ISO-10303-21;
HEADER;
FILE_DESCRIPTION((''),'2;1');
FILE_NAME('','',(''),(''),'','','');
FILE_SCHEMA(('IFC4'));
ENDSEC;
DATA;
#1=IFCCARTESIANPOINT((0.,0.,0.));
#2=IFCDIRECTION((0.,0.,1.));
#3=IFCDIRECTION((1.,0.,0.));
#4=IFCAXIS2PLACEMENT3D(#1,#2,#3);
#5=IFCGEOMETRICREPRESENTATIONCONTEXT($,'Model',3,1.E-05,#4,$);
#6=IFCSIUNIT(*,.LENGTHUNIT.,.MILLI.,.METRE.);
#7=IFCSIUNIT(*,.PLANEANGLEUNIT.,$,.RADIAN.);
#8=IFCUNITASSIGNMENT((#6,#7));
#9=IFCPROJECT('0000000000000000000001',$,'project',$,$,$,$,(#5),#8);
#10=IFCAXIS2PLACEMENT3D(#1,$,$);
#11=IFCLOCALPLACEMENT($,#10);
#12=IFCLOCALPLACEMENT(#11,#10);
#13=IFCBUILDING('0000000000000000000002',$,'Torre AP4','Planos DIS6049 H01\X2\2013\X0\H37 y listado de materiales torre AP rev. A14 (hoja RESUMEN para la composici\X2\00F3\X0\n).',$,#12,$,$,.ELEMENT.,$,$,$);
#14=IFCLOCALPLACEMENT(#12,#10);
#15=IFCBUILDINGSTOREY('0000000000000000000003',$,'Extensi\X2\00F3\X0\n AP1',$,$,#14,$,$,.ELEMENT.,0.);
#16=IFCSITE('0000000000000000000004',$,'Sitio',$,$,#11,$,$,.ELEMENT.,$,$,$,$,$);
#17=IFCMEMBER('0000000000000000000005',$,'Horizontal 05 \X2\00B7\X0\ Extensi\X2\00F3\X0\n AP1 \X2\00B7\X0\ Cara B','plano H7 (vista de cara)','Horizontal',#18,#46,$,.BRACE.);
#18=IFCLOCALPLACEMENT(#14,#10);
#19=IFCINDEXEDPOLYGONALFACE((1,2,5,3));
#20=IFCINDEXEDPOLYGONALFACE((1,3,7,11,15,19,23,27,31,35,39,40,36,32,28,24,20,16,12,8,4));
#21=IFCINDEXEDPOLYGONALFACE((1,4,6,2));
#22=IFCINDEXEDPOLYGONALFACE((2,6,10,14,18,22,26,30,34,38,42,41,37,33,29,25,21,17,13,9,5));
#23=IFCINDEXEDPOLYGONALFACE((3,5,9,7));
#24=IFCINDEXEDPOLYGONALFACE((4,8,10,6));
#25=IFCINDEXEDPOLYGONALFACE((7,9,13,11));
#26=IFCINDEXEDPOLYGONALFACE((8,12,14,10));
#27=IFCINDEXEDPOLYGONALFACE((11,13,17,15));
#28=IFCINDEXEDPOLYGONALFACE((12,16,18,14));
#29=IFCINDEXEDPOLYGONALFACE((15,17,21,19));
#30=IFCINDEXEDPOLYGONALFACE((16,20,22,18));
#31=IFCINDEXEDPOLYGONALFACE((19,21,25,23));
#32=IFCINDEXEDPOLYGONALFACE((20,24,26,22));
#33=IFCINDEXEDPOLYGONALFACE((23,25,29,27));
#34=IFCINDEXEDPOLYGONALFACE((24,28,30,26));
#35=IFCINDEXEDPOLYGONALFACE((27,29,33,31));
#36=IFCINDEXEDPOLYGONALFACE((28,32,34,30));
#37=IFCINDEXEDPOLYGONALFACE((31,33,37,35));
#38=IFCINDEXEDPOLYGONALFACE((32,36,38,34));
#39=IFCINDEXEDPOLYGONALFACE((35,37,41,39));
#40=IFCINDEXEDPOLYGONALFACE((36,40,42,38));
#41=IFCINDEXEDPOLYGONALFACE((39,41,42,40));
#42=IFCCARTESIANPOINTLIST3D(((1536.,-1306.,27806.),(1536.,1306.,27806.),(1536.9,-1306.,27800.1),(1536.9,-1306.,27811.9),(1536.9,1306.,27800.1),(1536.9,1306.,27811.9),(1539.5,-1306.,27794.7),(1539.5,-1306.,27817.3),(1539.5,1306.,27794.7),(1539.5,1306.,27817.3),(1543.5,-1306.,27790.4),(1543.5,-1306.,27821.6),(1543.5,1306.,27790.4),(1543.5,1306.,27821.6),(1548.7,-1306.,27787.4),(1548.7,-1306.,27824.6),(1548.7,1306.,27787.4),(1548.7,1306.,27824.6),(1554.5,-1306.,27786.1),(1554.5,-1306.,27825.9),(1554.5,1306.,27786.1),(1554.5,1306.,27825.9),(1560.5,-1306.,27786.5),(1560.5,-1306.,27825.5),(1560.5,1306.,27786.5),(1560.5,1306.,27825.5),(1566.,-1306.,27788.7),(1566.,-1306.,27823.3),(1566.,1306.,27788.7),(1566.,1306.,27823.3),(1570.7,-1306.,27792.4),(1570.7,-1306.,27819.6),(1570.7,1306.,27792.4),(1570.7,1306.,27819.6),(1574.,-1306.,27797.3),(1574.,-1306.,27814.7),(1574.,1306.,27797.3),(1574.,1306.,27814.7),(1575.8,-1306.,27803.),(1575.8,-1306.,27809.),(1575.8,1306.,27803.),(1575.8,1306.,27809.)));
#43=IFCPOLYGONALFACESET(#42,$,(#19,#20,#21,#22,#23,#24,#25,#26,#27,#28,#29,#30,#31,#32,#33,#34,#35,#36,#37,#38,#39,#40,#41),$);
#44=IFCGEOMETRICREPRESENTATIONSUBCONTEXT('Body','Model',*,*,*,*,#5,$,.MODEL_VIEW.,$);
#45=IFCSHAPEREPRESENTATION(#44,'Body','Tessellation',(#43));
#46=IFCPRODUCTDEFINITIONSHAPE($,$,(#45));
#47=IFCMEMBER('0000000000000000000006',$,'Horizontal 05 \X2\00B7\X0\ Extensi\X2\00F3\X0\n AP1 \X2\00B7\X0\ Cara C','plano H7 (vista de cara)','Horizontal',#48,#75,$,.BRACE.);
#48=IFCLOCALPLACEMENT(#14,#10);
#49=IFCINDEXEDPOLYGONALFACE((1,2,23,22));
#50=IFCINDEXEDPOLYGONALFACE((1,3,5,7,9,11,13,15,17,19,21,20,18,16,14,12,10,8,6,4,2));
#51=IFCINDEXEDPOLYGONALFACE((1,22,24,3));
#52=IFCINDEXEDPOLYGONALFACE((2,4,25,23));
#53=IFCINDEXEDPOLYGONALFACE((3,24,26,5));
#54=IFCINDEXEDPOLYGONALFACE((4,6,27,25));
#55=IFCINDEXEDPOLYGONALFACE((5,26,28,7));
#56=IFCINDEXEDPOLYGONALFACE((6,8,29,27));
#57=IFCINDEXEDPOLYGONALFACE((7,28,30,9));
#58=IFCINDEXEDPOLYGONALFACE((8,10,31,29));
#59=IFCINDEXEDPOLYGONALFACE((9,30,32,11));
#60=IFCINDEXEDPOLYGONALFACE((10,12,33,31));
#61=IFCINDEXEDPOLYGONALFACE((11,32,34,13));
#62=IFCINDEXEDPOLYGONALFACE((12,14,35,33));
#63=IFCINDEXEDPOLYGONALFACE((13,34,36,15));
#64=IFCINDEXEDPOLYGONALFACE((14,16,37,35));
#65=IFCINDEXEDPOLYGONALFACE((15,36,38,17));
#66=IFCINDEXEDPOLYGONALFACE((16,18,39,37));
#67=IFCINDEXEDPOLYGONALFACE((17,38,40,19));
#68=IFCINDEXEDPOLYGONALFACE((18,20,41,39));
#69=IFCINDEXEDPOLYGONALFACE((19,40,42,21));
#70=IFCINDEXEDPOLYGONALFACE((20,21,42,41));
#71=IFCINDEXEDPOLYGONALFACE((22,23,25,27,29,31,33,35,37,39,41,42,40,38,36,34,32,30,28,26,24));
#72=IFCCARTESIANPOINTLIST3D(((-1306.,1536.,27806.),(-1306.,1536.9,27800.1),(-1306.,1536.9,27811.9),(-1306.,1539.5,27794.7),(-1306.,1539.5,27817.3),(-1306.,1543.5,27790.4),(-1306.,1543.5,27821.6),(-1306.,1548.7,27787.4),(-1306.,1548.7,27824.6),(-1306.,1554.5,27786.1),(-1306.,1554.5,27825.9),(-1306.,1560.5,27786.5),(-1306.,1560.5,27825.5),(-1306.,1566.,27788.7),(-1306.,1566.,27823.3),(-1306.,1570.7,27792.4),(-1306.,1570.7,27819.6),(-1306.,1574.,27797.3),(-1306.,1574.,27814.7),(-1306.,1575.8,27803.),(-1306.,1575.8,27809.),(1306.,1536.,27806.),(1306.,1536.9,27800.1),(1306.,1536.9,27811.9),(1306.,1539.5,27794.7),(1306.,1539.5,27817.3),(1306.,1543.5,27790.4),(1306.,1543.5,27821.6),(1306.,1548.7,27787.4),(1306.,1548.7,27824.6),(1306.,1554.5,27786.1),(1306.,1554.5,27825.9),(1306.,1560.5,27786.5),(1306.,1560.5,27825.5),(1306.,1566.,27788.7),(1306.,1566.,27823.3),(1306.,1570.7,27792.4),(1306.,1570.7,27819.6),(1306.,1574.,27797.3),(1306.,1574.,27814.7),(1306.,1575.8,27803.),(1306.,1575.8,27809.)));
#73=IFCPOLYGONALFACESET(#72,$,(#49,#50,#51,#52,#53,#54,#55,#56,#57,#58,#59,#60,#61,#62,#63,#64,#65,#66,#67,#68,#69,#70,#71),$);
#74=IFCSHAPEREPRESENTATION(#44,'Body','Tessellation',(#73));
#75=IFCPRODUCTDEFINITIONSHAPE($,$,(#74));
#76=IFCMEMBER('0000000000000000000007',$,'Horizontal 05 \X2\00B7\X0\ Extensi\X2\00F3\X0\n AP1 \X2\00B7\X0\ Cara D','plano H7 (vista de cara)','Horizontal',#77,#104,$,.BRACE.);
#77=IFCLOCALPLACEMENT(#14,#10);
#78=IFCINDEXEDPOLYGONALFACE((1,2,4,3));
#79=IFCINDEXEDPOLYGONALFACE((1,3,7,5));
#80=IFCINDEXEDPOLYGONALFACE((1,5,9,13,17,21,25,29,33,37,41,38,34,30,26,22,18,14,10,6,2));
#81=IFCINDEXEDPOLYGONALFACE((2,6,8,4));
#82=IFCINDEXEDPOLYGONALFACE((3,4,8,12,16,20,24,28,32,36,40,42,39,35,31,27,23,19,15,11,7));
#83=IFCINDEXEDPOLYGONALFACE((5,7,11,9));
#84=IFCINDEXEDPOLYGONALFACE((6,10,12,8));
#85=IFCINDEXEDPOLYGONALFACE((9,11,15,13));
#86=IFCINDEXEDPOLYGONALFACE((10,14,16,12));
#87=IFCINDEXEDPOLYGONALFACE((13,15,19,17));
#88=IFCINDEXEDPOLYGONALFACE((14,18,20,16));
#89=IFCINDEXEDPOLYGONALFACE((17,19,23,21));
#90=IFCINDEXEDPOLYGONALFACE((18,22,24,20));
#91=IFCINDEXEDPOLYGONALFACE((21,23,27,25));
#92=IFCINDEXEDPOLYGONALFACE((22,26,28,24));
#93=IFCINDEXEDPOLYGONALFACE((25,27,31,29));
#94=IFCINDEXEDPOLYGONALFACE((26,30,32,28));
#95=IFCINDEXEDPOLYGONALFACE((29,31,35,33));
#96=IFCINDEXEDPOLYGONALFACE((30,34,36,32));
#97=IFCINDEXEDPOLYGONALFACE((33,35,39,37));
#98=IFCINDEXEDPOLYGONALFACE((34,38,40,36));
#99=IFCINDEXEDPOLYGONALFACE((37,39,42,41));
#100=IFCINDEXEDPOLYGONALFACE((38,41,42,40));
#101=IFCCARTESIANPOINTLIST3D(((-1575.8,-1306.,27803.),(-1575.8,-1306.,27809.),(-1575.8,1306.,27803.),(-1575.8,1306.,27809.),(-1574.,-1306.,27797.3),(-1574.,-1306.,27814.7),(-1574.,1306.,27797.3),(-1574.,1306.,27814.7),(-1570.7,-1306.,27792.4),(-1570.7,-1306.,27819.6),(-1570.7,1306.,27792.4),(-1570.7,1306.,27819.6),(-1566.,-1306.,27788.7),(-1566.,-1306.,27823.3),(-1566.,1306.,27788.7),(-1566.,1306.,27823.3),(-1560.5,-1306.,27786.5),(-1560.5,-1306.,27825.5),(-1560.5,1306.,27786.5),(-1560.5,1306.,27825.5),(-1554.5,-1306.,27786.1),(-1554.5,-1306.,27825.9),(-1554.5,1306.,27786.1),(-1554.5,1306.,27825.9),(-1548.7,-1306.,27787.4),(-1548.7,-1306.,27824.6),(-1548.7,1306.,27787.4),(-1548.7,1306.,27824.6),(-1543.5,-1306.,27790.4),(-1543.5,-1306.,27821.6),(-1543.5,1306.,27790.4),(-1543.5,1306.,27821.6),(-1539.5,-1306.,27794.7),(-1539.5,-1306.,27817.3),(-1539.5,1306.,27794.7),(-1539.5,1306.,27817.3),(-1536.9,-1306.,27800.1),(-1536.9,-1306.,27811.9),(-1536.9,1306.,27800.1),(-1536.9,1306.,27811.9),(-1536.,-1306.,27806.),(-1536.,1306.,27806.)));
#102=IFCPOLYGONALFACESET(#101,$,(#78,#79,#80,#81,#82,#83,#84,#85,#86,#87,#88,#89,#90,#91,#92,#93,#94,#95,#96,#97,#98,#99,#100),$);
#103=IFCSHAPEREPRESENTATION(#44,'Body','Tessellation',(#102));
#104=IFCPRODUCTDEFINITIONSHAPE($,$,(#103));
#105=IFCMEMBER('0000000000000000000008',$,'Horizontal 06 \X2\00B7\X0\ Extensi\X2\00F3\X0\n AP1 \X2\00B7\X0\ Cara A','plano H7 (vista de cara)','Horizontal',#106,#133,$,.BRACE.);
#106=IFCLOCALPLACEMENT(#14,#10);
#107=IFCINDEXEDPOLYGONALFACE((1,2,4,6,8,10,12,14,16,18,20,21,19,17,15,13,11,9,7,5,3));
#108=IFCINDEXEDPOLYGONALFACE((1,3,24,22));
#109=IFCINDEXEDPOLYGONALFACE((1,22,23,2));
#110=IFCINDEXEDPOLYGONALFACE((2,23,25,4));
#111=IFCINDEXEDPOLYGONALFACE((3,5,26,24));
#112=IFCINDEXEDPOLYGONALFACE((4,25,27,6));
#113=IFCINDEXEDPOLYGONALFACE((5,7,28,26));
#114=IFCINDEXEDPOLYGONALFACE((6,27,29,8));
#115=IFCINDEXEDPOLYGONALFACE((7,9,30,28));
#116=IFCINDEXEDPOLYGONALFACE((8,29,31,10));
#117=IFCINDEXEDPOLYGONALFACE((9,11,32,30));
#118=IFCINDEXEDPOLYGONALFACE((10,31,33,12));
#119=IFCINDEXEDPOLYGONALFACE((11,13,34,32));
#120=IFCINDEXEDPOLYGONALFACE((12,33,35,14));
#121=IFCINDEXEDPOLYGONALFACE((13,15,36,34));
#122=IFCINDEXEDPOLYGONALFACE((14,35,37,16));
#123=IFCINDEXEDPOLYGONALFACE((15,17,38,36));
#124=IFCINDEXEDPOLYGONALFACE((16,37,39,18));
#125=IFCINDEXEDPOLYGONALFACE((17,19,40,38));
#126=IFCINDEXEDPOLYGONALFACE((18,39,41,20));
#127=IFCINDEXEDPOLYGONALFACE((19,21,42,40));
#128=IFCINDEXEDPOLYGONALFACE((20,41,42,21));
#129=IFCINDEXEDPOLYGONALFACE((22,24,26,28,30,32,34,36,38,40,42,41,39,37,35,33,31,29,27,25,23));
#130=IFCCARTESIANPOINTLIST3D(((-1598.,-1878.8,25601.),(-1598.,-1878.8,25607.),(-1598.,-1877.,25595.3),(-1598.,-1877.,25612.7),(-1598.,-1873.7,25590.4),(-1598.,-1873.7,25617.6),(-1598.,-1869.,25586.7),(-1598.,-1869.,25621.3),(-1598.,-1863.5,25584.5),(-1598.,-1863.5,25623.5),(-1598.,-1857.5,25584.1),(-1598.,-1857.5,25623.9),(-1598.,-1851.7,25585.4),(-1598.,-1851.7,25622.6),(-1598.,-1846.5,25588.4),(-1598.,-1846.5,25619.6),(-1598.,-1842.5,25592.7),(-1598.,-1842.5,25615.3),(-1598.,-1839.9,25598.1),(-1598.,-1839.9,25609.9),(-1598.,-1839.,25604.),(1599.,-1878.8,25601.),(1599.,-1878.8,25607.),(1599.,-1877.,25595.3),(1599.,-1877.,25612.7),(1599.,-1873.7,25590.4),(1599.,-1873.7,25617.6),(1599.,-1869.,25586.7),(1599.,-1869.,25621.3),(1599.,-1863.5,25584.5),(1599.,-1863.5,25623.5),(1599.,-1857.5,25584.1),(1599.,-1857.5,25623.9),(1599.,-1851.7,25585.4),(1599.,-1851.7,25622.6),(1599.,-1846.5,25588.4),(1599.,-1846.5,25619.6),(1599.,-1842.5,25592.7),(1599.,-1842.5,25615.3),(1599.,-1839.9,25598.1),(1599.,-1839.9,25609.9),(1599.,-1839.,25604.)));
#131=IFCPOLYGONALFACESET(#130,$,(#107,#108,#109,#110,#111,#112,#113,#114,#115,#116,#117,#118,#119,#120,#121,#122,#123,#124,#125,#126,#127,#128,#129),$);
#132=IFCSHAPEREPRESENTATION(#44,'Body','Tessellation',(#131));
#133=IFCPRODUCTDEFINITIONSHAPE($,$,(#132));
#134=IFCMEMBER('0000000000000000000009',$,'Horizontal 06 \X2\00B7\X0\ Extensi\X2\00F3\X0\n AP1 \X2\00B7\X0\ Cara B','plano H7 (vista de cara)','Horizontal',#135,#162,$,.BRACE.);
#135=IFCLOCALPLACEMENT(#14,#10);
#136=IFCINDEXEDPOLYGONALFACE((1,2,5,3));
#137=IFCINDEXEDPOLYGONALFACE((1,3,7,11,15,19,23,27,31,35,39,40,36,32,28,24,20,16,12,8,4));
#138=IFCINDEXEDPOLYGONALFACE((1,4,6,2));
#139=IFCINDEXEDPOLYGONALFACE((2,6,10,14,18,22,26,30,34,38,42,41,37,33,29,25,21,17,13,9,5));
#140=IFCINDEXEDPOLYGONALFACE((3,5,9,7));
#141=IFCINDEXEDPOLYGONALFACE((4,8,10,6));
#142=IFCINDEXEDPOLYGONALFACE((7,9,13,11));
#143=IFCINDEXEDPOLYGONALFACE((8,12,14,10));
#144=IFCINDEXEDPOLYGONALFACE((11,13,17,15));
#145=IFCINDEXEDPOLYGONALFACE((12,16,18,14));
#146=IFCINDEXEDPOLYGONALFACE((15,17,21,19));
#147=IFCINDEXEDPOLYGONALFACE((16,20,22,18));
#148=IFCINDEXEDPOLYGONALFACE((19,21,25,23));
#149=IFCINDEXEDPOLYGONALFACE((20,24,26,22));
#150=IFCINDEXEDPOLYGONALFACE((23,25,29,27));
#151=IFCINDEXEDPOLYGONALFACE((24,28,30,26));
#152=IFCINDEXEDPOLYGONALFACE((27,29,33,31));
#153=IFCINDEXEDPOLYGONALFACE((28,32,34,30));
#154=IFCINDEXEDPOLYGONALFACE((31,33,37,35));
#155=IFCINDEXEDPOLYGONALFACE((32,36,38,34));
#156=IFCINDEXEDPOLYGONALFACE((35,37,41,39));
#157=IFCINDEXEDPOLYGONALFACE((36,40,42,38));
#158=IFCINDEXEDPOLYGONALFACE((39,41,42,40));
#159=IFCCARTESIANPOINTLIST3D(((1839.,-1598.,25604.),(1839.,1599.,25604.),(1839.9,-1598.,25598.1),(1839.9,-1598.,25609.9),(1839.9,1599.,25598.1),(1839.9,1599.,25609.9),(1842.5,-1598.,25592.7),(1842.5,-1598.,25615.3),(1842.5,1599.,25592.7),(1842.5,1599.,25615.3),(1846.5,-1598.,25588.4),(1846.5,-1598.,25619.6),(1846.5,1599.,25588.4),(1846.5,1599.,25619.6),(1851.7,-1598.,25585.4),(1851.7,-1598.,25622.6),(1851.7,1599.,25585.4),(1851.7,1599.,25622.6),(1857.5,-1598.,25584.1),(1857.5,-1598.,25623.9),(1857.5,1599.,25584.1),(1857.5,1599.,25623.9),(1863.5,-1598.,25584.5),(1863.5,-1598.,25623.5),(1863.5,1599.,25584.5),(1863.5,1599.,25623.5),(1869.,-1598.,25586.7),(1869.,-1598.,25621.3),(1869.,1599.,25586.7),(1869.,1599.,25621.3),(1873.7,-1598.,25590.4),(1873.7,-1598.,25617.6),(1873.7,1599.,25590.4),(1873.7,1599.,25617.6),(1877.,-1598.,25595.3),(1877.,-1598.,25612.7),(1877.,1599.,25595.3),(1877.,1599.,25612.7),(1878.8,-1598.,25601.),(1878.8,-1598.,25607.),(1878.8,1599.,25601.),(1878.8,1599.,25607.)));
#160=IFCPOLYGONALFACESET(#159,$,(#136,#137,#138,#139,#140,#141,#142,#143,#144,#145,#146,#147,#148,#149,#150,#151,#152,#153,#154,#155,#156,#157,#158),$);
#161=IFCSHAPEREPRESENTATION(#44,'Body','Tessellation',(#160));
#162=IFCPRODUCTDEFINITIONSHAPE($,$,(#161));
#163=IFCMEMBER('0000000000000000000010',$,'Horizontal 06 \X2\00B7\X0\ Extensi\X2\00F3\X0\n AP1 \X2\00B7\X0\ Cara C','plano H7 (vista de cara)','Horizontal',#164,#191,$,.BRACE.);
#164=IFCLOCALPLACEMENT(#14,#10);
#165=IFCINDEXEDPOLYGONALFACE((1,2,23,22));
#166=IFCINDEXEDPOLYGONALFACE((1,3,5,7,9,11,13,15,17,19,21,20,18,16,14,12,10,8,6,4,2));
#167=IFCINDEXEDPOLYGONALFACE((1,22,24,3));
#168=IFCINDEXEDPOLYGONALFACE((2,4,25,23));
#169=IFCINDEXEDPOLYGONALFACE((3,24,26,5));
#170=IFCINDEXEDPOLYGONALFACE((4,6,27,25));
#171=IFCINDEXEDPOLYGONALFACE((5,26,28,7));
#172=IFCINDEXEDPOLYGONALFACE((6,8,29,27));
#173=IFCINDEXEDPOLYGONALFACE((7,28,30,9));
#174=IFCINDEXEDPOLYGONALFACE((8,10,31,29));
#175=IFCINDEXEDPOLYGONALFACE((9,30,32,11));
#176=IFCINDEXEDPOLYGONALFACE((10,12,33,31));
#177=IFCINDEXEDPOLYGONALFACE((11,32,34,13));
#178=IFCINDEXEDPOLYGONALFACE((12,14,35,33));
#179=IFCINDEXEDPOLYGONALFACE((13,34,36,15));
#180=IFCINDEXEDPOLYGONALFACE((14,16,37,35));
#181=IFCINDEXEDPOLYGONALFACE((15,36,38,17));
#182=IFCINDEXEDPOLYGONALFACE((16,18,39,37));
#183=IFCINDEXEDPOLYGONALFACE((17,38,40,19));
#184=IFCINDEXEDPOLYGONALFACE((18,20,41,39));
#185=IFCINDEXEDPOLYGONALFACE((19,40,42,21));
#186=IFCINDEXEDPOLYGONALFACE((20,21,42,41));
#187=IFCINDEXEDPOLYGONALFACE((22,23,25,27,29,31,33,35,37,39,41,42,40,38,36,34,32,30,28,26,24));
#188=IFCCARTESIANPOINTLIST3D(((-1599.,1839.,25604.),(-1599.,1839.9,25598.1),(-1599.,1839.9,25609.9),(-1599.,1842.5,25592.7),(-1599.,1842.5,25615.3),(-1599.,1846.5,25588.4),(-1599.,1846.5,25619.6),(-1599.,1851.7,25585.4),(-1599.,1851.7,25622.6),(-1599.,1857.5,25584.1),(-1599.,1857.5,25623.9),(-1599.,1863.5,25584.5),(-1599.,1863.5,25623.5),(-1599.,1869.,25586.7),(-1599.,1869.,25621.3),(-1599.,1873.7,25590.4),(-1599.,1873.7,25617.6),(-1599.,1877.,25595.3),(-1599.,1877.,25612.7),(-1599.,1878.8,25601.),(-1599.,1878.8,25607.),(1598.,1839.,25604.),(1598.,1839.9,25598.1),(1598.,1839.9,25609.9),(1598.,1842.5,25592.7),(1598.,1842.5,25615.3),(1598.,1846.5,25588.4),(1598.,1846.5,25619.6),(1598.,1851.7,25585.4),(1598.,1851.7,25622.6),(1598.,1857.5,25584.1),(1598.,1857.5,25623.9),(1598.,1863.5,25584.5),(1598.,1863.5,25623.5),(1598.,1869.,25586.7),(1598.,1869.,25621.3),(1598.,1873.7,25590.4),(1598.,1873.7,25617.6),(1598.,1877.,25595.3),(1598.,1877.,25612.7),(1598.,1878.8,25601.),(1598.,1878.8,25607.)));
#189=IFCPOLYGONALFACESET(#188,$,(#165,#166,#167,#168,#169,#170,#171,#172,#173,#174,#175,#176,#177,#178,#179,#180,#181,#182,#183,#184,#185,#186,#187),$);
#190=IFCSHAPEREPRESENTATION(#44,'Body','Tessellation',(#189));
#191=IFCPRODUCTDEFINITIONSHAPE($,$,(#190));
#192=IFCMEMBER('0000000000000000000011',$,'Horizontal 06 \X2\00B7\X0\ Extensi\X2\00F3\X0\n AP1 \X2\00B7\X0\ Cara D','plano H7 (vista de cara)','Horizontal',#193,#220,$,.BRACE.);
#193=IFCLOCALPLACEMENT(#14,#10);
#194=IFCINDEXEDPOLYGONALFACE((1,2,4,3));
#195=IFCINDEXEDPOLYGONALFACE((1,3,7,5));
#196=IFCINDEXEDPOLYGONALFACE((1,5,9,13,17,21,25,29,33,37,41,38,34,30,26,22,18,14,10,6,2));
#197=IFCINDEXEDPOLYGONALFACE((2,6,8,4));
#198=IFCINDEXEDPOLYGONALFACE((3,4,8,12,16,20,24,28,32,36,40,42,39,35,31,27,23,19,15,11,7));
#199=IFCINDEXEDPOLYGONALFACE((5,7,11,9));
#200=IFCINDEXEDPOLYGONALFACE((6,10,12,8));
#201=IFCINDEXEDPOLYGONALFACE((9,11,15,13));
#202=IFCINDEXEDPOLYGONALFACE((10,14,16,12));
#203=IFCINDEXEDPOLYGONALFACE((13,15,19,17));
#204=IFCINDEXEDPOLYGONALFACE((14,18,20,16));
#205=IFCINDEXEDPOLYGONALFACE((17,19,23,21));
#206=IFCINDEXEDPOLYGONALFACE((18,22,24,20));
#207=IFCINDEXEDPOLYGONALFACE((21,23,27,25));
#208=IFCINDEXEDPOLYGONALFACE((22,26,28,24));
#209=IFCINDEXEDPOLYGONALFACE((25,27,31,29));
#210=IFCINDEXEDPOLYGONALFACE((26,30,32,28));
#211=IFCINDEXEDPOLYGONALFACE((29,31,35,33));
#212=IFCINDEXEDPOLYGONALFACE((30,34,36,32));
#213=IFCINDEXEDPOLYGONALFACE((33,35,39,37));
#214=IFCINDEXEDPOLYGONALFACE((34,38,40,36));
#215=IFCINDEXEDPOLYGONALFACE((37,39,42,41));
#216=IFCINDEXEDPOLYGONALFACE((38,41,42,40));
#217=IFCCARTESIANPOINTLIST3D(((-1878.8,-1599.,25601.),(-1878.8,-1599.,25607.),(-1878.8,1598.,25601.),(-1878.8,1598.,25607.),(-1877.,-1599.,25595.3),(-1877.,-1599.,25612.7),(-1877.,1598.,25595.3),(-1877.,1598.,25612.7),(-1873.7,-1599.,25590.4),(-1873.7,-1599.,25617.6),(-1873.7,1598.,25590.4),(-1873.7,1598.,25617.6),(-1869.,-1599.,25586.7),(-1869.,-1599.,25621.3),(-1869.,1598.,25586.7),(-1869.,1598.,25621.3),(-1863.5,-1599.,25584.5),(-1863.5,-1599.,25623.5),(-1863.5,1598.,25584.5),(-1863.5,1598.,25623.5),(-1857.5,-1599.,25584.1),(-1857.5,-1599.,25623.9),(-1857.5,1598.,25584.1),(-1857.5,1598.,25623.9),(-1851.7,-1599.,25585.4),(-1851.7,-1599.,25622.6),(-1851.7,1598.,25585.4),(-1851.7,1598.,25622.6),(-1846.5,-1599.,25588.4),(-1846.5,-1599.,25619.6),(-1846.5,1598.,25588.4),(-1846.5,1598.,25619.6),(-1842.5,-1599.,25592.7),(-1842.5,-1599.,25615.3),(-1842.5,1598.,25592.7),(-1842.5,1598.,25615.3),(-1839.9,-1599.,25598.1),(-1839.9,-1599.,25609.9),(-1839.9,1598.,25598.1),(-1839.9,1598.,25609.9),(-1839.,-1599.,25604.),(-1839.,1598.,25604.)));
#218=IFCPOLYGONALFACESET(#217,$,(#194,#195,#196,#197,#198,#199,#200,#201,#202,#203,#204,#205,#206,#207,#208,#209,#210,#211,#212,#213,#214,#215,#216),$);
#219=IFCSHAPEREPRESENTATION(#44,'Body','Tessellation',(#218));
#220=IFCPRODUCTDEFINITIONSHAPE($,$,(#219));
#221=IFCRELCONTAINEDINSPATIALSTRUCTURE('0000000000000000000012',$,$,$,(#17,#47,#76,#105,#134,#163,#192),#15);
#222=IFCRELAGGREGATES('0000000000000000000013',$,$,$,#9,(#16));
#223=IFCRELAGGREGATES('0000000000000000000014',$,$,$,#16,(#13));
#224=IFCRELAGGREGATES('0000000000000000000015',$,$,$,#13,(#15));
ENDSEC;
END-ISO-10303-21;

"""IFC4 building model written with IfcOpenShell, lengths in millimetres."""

from ifc_helpers import new_model, si_unit, frame, origin, origin_with_axes, place, context, subcontext, project, spatial, circle, extrude, element, save


model = new_model("IFC4")

# Units and contexts
model_context = context("Model", 3, precision=1e-05, world=origin_with_axes())
body_context = subcontext(model_context, "Body", "Model", "MODEL_VIEW")
ifc_project = project(units=[si_unit("LENGTHUNIT", "METRE", prefix="MILLI"), si_unit("PLANEANGLEUNIT", "RADIAN")], contexts=[model_context])

# Site, building, storey
site_placement = place(None, origin())
site = spatial("IfcSite", under=ifc_project, at=site_placement, Name="Sitio", CompositionType="ELEMENT")
building_placement = place(site_placement, origin())
building = spatial("IfcBuilding", under=site, at=building_placement, Name="Torre AP4", Description="Planos DIS6049 H01–H37 y listado de materiales torre AP rev. A14 (hoja RESUMEN para la composición).", CompositionType="ELEMENT")
storey_placement = place(building_placement, origin())
storey = spatial("IfcBuildingStorey", under=building, at=storey_placement, Name="Extensión AP1", CompositionType="ELEMENT", Elevation=0.0)

# Members
for number, where, z_axis, x_axis, name in (
    (1, (1556.0, 1306.0, 27806.0), (0.0, -1.0, 0.0), (-1.0, 0.0, 0.0), "Horizontal 05 · Extensión AP1 · Cara B"),
    (2, (-1306.0, 1556.0, 27806.0), (1.0, 0.0, 0.0), (0.0, -1.0, 0.0), "Horizontal 05 · Extensión AP1 · Cara C"),
    (3, (-1556.0, -1306.0, 27806.0), (0.0, 1.0, 0.0), (1.0, 0.0, 0.0), "Horizontal 05 · Extensión AP1 · Cara D"),
):
    element("IfcMember", number, at=place(storey_placement, frame(where, z_axis=z_axis, x_axis=x_axis)), inside=storey, Name=name, Description="plano H7 (vista de cara)", ObjectType="Horizontal", PredefinedType="BRACE", context=body_context, shape_type="SweptSolid", body=[
        extrude(circle(Radius=20.0), None, (0.0, 0.0, 1.0), 2612.0),
    ])
for number, where, z_axis, x_axis, name in (
    (4, (1599.0, -1859.0, 25604.0), (-1.0, 0.0, 0.0), (0.0, 1.0, 0.0), "Horizontal 06 · Extensión AP1 · Cara A"),
    (5, (1859.0, 1599.0, 25604.0), (0.0, -1.0, 0.0), (-1.0, 0.0, 0.0), "Horizontal 06 · Extensión AP1 · Cara B"),
    (6, (-1599.0, 1859.0, 25604.0), (1.0, 0.0, 0.0), (0.0, -1.0, 0.0), "Horizontal 06 · Extensión AP1 · Cara C"),
    (7, (-1859.0, -1599.0, 25604.0), (0.0, 1.0, 0.0), (1.0, 0.0, 0.0), "Horizontal 06 · Extensión AP1 · Cara D"),
):
    element("IfcMember", number, at=place(storey_placement, frame(where, z_axis=z_axis, x_axis=x_axis)), inside=storey, Name=name, Description="plano H7 (vista de cara)", ObjectType="Horizontal", PredefinedType="BRACE", context=body_context, shape_type="SweptSolid", body=[
        extrude(circle(Radius=20.0), None, (0.0, 0.0, 1.0), 3197.0),
    ])

save(model, "model.ifc")
